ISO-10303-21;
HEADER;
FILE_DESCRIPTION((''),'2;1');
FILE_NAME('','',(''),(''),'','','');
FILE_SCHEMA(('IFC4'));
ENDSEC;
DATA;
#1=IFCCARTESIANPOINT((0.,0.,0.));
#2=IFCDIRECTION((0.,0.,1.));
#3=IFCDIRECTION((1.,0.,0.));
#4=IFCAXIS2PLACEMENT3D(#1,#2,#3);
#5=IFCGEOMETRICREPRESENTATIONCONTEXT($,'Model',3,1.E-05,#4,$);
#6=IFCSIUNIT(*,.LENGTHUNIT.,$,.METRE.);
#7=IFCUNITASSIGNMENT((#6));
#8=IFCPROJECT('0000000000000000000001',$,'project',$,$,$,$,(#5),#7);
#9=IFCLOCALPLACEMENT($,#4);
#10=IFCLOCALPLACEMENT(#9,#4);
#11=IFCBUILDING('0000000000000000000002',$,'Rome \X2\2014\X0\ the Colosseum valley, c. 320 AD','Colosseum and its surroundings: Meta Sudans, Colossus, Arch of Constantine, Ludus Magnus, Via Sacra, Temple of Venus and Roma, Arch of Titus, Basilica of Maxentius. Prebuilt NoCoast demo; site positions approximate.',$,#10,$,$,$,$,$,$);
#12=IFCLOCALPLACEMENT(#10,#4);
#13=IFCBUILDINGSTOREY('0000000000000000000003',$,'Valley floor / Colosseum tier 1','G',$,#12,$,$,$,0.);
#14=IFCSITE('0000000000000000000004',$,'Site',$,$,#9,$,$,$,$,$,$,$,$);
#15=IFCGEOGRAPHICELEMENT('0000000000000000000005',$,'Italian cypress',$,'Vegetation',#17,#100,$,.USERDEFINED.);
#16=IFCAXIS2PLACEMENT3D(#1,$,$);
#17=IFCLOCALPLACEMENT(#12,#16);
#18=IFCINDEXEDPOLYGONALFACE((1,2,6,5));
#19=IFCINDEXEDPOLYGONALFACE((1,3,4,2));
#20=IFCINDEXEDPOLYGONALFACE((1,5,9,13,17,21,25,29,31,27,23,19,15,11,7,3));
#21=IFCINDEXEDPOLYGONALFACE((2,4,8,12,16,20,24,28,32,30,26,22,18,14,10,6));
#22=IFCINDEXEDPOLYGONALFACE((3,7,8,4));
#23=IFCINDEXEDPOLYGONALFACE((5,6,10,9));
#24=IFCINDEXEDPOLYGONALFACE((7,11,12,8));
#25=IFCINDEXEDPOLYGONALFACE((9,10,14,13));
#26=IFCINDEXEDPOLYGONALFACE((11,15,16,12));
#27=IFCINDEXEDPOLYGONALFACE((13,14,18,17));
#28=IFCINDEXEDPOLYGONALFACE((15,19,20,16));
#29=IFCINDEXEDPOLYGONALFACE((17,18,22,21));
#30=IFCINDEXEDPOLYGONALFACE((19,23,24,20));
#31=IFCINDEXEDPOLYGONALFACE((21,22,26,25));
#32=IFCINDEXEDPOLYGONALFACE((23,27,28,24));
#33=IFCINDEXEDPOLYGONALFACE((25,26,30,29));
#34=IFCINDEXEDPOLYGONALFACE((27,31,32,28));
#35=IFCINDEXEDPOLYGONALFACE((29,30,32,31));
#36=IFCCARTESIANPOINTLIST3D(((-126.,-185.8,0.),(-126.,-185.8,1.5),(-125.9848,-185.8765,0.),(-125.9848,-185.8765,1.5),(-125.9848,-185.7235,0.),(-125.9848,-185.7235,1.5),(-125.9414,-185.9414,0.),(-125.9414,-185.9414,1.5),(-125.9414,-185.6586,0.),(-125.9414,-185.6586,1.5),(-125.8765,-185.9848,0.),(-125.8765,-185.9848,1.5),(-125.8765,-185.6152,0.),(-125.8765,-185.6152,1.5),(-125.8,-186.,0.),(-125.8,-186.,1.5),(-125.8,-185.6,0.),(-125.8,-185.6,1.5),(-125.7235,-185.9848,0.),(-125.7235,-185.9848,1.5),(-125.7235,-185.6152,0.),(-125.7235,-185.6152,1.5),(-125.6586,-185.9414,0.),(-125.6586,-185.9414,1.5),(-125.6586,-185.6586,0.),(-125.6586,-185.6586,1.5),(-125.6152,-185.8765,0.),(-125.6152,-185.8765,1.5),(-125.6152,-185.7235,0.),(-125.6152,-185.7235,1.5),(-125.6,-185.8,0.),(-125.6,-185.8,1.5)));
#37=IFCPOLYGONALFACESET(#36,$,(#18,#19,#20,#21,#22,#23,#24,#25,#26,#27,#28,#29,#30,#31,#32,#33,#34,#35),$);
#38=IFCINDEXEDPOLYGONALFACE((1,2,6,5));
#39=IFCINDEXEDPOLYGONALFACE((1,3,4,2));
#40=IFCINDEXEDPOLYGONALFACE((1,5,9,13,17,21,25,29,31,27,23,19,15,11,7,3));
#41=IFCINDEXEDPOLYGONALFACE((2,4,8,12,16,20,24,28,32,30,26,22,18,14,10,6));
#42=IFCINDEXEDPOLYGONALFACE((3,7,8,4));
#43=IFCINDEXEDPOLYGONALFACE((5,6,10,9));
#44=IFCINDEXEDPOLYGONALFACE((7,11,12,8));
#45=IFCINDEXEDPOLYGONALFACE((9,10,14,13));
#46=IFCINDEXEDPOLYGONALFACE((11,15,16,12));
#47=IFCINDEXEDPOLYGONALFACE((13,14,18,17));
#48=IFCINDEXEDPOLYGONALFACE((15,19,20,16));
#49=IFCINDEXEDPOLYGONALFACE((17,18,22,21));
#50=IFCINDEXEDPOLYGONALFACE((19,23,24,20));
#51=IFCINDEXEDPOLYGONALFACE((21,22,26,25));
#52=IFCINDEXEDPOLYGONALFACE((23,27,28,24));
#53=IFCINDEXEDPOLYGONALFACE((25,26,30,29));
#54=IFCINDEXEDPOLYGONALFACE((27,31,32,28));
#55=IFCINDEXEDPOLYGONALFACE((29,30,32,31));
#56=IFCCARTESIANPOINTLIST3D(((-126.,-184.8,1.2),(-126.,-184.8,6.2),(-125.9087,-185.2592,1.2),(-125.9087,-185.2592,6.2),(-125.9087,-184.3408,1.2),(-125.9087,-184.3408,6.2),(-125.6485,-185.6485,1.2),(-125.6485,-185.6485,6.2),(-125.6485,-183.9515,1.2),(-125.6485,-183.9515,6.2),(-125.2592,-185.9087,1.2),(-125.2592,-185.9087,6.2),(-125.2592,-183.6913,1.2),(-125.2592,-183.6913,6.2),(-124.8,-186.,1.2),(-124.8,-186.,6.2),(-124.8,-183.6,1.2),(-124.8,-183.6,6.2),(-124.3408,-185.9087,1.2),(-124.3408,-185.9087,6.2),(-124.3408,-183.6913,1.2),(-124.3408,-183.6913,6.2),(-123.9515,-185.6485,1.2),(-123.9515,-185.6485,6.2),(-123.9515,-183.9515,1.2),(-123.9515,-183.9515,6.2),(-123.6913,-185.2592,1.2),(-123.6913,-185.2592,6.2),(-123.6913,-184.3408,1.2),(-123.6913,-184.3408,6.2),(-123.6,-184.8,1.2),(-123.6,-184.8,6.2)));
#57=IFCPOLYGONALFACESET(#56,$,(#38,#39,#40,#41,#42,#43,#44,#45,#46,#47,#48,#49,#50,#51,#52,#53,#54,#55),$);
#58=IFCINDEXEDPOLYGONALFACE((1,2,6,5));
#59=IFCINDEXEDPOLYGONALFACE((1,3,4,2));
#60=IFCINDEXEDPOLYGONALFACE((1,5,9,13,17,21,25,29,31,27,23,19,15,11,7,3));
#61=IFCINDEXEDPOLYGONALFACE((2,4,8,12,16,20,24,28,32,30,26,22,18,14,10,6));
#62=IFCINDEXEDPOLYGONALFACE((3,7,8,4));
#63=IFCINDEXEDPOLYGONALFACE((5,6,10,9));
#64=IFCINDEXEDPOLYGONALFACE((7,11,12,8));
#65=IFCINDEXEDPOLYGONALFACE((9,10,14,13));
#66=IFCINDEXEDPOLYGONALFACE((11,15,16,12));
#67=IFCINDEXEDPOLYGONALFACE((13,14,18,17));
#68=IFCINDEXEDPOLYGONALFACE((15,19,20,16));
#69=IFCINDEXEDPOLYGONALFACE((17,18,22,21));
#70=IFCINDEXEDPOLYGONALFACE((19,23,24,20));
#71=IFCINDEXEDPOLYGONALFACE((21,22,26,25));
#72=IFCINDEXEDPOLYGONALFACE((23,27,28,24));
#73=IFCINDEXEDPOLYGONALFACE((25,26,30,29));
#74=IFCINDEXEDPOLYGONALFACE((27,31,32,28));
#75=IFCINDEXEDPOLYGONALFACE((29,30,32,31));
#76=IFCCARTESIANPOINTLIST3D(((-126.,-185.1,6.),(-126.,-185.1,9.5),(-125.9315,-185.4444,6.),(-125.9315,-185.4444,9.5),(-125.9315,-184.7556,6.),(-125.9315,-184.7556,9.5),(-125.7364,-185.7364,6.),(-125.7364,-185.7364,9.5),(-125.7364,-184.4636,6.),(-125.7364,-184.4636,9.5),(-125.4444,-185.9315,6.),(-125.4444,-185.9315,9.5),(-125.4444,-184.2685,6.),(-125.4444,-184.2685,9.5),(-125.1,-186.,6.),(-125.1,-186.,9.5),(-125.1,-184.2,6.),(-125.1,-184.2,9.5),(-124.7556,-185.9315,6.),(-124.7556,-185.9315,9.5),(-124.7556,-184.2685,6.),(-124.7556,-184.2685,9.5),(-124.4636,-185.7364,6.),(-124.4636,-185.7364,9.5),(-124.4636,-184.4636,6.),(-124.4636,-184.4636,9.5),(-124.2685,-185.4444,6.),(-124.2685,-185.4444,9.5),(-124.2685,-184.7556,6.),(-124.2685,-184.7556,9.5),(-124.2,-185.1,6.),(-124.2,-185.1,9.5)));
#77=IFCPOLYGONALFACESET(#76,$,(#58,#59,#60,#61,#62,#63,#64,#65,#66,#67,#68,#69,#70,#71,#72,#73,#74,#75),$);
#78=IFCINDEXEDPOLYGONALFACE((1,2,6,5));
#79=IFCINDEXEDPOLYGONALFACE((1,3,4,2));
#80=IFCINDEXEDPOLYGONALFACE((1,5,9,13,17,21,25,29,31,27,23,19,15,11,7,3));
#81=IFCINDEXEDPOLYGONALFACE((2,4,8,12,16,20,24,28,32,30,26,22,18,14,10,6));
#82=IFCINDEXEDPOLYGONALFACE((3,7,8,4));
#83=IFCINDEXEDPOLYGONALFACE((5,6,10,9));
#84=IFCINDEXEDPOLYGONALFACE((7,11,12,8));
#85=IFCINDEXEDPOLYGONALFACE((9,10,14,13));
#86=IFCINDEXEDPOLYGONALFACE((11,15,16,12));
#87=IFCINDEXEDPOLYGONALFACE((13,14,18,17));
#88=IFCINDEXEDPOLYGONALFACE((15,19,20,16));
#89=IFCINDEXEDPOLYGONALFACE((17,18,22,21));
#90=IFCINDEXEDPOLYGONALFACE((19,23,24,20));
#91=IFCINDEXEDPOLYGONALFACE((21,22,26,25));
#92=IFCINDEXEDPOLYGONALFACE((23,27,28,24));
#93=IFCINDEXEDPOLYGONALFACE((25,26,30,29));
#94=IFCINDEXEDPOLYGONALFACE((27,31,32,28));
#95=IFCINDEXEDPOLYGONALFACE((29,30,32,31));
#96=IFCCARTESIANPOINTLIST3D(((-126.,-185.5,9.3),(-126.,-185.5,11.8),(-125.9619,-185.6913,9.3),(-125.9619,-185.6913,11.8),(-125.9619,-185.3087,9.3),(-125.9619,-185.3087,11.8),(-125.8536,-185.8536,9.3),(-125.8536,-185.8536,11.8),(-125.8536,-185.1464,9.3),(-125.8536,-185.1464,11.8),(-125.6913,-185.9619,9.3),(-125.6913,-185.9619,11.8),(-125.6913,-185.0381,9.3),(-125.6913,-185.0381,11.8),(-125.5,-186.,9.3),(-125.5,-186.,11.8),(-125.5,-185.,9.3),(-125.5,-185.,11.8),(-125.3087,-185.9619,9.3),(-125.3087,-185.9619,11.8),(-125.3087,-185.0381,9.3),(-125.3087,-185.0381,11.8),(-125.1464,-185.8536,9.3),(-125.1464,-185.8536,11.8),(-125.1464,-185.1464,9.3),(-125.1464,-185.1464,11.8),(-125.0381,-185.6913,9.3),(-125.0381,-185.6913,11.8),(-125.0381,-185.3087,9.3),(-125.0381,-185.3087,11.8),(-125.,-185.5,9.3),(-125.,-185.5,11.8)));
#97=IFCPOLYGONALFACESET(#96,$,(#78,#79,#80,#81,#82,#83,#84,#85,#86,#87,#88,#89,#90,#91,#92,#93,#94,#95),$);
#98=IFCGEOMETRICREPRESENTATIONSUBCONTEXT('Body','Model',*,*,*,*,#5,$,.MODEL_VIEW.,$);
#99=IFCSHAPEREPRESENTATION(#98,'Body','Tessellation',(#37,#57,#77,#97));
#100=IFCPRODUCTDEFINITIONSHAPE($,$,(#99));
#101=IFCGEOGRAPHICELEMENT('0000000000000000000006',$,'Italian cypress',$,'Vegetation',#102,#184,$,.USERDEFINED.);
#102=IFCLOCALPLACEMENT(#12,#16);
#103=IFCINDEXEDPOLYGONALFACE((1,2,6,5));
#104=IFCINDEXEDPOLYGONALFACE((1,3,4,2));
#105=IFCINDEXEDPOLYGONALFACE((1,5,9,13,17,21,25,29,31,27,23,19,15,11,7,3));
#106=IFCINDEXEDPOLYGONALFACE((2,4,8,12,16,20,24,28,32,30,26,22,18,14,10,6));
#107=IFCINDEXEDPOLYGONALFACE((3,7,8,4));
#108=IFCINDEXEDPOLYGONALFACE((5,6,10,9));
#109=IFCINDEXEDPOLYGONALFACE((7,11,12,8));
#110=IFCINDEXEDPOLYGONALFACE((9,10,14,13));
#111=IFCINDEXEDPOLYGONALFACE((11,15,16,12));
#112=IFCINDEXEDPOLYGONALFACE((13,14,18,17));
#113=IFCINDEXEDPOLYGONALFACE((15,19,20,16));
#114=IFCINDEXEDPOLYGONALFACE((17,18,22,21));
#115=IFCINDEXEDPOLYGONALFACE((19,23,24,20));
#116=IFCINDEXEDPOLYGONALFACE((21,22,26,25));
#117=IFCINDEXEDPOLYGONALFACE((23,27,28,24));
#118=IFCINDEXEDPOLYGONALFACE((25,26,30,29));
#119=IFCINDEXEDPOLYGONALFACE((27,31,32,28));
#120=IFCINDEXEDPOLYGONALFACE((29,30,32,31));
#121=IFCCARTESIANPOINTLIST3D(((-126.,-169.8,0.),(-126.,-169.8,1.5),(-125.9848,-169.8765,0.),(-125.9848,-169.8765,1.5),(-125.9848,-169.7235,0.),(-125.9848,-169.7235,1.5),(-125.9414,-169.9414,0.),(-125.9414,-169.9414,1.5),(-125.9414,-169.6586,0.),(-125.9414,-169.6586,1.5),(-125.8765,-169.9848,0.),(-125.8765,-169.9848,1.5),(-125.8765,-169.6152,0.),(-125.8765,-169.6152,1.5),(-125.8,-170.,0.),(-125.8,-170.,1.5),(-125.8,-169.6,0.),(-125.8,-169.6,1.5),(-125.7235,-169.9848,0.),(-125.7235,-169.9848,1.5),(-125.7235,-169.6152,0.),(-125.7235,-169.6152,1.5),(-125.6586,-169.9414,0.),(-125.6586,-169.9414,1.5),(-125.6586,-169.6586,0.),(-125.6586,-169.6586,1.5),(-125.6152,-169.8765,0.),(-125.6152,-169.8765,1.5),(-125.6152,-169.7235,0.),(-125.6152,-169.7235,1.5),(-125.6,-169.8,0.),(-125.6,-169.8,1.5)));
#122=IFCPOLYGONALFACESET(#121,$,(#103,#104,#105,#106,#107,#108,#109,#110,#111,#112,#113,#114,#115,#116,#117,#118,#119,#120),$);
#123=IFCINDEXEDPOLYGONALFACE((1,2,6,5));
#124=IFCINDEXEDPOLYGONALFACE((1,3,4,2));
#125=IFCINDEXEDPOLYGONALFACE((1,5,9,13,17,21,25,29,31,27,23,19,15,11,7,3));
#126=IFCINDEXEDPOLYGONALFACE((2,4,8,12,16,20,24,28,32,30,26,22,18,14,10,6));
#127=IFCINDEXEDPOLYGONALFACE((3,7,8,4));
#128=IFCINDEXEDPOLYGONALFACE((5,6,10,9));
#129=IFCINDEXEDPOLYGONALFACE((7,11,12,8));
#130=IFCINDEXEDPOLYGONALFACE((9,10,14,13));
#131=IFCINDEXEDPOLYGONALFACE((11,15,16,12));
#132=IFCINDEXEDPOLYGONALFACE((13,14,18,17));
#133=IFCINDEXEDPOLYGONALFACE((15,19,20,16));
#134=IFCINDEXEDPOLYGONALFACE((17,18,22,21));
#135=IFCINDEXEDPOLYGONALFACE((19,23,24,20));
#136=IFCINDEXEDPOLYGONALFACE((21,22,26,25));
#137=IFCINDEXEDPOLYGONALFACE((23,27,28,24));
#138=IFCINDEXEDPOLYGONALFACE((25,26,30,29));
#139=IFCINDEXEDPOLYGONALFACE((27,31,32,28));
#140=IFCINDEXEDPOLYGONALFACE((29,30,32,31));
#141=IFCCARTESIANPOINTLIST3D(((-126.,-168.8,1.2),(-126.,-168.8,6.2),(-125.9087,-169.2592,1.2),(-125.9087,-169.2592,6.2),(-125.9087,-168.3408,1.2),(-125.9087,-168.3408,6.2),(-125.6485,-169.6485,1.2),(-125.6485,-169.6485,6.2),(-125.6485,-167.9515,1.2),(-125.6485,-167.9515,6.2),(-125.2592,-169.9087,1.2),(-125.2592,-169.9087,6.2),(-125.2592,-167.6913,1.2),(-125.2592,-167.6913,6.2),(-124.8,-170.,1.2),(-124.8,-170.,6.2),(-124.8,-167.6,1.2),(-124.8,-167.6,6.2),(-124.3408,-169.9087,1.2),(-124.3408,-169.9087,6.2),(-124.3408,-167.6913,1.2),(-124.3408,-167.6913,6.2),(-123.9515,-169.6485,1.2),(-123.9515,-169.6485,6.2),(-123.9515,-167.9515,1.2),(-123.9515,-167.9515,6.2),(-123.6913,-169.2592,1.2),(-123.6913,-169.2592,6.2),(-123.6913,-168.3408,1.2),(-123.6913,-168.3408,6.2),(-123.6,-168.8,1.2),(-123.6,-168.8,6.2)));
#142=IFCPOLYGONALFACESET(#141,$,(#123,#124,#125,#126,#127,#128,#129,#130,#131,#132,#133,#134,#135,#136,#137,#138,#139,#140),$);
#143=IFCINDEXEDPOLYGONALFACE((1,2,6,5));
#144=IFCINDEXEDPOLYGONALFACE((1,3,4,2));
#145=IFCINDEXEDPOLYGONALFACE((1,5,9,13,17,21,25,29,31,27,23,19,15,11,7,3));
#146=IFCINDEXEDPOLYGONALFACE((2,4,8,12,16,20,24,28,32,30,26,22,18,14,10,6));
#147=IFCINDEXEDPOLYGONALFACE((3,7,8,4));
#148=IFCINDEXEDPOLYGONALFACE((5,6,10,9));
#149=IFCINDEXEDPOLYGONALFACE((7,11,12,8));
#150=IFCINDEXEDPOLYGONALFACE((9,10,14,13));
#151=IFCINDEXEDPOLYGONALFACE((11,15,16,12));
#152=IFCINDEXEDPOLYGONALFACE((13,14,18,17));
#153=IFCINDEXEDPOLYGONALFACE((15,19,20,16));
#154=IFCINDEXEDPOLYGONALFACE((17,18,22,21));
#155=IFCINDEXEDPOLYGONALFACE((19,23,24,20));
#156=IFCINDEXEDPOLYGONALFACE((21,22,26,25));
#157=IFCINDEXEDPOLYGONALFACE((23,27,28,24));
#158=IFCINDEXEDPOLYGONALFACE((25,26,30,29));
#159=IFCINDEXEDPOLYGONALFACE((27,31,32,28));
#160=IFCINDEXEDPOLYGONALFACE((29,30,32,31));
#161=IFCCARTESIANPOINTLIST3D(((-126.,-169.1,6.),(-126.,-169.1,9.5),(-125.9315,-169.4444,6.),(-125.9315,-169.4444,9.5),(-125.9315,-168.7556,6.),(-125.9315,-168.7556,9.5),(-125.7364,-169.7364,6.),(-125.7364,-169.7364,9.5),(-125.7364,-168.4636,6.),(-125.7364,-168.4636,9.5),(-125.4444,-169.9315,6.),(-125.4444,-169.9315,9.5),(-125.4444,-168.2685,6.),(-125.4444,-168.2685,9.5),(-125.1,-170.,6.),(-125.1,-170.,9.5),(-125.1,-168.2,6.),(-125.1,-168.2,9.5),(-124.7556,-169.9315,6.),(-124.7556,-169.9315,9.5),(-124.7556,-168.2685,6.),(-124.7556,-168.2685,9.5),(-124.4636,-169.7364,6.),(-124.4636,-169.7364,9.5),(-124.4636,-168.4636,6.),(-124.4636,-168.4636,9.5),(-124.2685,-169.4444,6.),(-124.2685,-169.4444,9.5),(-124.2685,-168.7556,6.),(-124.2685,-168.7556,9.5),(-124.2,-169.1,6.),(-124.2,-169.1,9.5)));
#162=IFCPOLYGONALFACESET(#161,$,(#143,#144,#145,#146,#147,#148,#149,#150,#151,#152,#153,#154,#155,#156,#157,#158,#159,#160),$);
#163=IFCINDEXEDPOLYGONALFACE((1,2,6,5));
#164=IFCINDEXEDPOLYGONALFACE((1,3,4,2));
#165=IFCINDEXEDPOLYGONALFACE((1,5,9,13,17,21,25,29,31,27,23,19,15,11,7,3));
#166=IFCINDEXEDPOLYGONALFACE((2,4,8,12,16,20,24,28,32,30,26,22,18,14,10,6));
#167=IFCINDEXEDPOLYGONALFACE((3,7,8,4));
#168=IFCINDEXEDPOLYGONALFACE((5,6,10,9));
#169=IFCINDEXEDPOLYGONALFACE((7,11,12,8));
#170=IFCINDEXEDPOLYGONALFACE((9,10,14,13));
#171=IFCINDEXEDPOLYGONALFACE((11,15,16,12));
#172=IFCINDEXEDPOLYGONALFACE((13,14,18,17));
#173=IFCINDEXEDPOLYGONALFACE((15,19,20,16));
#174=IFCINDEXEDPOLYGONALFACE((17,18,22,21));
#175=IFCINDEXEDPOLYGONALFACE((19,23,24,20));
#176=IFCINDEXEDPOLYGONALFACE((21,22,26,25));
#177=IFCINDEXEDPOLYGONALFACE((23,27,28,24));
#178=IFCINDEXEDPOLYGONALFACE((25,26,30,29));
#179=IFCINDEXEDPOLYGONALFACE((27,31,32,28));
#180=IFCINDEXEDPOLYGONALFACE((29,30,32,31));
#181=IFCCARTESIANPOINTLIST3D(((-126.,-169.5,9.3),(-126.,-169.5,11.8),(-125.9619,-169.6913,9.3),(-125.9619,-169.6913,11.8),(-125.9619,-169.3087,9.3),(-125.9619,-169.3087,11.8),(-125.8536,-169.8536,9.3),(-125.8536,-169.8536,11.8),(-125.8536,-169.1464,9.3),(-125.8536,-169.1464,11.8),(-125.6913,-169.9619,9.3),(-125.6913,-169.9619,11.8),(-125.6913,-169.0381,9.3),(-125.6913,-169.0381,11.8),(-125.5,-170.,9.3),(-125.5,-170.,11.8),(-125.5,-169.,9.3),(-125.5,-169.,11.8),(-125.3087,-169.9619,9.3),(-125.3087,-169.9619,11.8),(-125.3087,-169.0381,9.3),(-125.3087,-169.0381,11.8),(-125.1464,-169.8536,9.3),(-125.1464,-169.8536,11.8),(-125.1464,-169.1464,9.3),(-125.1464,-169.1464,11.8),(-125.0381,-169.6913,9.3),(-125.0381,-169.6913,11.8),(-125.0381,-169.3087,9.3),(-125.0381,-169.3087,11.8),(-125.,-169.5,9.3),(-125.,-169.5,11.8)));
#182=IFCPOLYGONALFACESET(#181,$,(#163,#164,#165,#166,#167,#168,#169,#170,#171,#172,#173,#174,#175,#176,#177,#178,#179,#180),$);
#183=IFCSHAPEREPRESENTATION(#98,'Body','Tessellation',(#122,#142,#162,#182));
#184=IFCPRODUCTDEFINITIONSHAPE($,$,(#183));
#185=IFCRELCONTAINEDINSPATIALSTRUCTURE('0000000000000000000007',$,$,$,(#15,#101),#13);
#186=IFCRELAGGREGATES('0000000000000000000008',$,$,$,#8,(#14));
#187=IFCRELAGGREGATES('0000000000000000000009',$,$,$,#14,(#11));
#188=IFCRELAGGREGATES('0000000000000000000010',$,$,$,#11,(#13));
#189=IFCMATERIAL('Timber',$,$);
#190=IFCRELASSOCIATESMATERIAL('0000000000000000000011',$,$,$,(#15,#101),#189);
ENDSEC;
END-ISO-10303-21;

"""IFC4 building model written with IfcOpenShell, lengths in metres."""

from ifc_helpers import new_model, si_unit, frame, origin_with_axes, place, context, subcontext, project, spatial, polyline, outline, extrude, material, element, save


model = new_model("IFC4")

# Units and contexts
model_context = context("Model", 3, precision=1e-05, world=origin_with_axes())
body_context = subcontext(model_context, "Body", "Model", "MODEL_VIEW")
ifc_project = project(units=[si_unit("LENGTHUNIT", "METRE")], contexts=[model_context])

# Site, building, storey
site_placement = place(None, origin_with_axes())
site = spatial("IfcSite", under=ifc_project, at=site_placement, Name="Site")
building_placement = place(site_placement, origin_with_axes())
building = spatial("IfcBuilding", under=site, at=building_placement, Name="Rome — the Colosseum valley, c. 320 AD", Description="Colosseum and its surroundings: Meta Sudans, Colossus, Arch of Constantine, Ludus Magnus, Via Sacra, Temple of Venus and Roma, Arch of Titus, Basilica of Maxentius. Prebuilt NoCoast demo; site positions approximate.")
storey_placement = place(building_placement, origin_with_axes())
storey = spatial("IfcBuildingStorey", under=building, at=storey_placement, Name="Valley floor / Colosseum tier 1", Description="G", Elevation=0.0)

# Shared definitions
ifc_material_1 = material(Name="Timber")

# Geographic elements
geographic_element_1_placement = place(storey_placement, frame((-126.0, -186.0, 0.0), z_axis=(0.0, 0.0, 1.0), x_axis=(1.0, 0.0, 0.0)))
element("IfcGeographicElement", 1, at=geographic_element_1_placement, inside=storey, material=ifc_material_1, Name="Italian cypress", ObjectType="Vegetation", PredefinedType="USERDEFINED", context=body_context, shape_type="SweptSolid", body=[
    extrude(outline(polyline([(0.4, 0.2), (0.3848, 0.2765), (0.3414, 0.3414), (0.2765, 0.3848), (0.2, 0.4), (0.1235, 0.3848), (0.0586, 0.3414), (0.0152, 0.2765), (0.0, 0.2), (0.0152, 0.1235), (0.0586, 0.0586), (0.1235, 0.0152), (0.2, 0.0), (0.2765, 0.0152), (0.3414, 0.0586), (0.3848, 0.1235), (0.4, 0.2)])), origin_with_axes(), (0.0, 0.0, 1.0), 1.5),
    extrude(outline(polyline([(2.4, 1.2), (2.3087, 1.6592), (2.0485, 2.0485), (1.6592, 2.3087), (1.2, 2.4), (0.7408, 2.3087), (0.3515, 2.0485), (0.0913, 1.6592), (0.0, 1.2), (0.0913, 0.7408), (0.3515, 0.3515), (0.7408, 0.0913), (1.2, 0.0), (1.6592, 0.0913), (2.0485, 0.3515), (2.3087, 0.7408), (2.4, 1.2)])), frame((0.0, 0.0, 1.2), z_axis=(0.0, 0.0, 1.0), x_axis=(1.0, 0.0, 0.0)), (0.0, 0.0, 1.0), 5.0),
    extrude(outline(polyline([(1.8, 0.9), (1.7315, 1.2444), (1.5364, 1.5364), (1.2444, 1.7315), (0.9, 1.8), (0.5556, 1.7315), (0.2636, 1.5364), (0.0685, 1.2444), (0.0, 0.9), (0.0685, 0.5556), (0.2636, 0.2636), (0.5556, 0.0685), (0.9, 0.0), (1.2444, 0.0685), (1.5364, 0.2636), (1.7315, 0.5556), (1.8, 0.9)])), frame((0.0, 0.0, 6.0), z_axis=(0.0, 0.0, 1.0), x_axis=(1.0, 0.0, 0.0)), (0.0, 0.0, 1.0), 3.5),
    extrude(outline(polyline([(1.0, 0.5), (0.9619, 0.6913), (0.8536, 0.8536), (0.6913, 0.9619), (0.5, 1.0), (0.3087, 0.9619), (0.1464, 0.8536), (0.0381, 0.6913), (0.0, 0.5), (0.0381, 0.3087), (0.1464, 0.1464), (0.3087, 0.0381), (0.5, 0.0), (0.6913, 0.0381), (0.8536, 0.1464), (0.9619, 0.3087), (1.0, 0.5)])), frame((0.0, 0.0, 9.3), z_axis=(0.0, 0.0, 1.0), x_axis=(1.0, 0.0, 0.0)), (0.0, 0.0, 1.0), 2.5),
])
geographic_element_2_placement = place(storey_placement, frame((-126.0, -170.0, 0.0), z_axis=(0.0, 0.0, 1.0), x_axis=(1.0, 0.0, 0.0)))
element("IfcGeographicElement", 2, at=geographic_element_2_placement, inside=storey, material=ifc_material_1, Name="Italian cypress", ObjectType="Vegetation", PredefinedType="USERDEFINED", context=body_context, shape_type="SweptSolid", body=[
    extrude(outline(polyline([(0.4, 0.2), (0.3848, 0.2765), (0.3414, 0.3414), (0.2765, 0.3848), (0.2, 0.4), (0.1235, 0.3848), (0.0586, 0.3414), (0.0152, 0.2765), (0.0, 0.2), (0.0152, 0.1235), (0.0586, 0.0586), (0.1235, 0.0152), (0.2, 0.0), (0.2765, 0.0152), (0.3414, 0.0586), (0.3848, 0.1235), (0.4, 0.2)])), origin_with_axes(), (0.0, 0.0, 1.0), 1.5),
    extrude(outline(polyline([(2.4, 1.2), (2.3087, 1.6592), (2.0485, 2.0485), (1.6592, 2.3087), (1.2, 2.4), (0.7408, 2.3087), (0.3515, 2.0485), (0.0913, 1.6592), (0.0, 1.2), (0.0913, 0.7408), (0.3515, 0.3515), (0.7408, 0.0913), (1.2, 0.0), (1.6592, 0.0913), (2.0485, 0.3515), (2.3087, 0.7408), (2.4, 1.2)])), frame((0.0, 0.0, 1.2), z_axis=(0.0, 0.0, 1.0), x_axis=(1.0, 0.0, 0.0)), (0.0, 0.0, 1.0), 5.0),
    extrude(outline(polyline([(1.8, 0.9), (1.7315, 1.2444), (1.5364, 1.5364), (1.2444, 1.7315), (0.9, 1.8), (0.5556, 1.7315), (0.2636, 1.5364), (0.0685, 1.2444), (0.0, 0.9), (0.0685, 0.5556), (0.2636, 0.2636), (0.5556, 0.0685), (0.9, 0.0), (1.2444, 0.0685), (1.5364, 0.2636), (1.7315, 0.5556), (1.8, 0.9)])), frame((0.0, 0.0, 6.0), z_axis=(0.0, 0.0, 1.0), x_axis=(1.0, 0.0, 0.0)), (0.0, 0.0, 1.0), 3.5),
    extrude(outline(polyline([(1.0, 0.5), (0.9619, 0.6913), (0.8536, 0.8536), (0.6913, 0.9619), (0.5, 1.0), (0.3087, 0.9619), (0.1464, 0.8536), (0.0381, 0.6913), (0.0, 0.5), (0.0381, 0.3087), (0.1464, 0.1464), (0.3087, 0.0381), (0.5, 0.0), (0.6913, 0.0381), (0.8536, 0.1464), (0.9619, 0.3087), (1.0, 0.5)])), frame((0.0, 0.0, 9.3), z_axis=(0.0, 0.0, 1.0), x_axis=(1.0, 0.0, 0.0)), (0.0, 0.0, 1.0), 2.5),
])

save(model, "model.ifc")
